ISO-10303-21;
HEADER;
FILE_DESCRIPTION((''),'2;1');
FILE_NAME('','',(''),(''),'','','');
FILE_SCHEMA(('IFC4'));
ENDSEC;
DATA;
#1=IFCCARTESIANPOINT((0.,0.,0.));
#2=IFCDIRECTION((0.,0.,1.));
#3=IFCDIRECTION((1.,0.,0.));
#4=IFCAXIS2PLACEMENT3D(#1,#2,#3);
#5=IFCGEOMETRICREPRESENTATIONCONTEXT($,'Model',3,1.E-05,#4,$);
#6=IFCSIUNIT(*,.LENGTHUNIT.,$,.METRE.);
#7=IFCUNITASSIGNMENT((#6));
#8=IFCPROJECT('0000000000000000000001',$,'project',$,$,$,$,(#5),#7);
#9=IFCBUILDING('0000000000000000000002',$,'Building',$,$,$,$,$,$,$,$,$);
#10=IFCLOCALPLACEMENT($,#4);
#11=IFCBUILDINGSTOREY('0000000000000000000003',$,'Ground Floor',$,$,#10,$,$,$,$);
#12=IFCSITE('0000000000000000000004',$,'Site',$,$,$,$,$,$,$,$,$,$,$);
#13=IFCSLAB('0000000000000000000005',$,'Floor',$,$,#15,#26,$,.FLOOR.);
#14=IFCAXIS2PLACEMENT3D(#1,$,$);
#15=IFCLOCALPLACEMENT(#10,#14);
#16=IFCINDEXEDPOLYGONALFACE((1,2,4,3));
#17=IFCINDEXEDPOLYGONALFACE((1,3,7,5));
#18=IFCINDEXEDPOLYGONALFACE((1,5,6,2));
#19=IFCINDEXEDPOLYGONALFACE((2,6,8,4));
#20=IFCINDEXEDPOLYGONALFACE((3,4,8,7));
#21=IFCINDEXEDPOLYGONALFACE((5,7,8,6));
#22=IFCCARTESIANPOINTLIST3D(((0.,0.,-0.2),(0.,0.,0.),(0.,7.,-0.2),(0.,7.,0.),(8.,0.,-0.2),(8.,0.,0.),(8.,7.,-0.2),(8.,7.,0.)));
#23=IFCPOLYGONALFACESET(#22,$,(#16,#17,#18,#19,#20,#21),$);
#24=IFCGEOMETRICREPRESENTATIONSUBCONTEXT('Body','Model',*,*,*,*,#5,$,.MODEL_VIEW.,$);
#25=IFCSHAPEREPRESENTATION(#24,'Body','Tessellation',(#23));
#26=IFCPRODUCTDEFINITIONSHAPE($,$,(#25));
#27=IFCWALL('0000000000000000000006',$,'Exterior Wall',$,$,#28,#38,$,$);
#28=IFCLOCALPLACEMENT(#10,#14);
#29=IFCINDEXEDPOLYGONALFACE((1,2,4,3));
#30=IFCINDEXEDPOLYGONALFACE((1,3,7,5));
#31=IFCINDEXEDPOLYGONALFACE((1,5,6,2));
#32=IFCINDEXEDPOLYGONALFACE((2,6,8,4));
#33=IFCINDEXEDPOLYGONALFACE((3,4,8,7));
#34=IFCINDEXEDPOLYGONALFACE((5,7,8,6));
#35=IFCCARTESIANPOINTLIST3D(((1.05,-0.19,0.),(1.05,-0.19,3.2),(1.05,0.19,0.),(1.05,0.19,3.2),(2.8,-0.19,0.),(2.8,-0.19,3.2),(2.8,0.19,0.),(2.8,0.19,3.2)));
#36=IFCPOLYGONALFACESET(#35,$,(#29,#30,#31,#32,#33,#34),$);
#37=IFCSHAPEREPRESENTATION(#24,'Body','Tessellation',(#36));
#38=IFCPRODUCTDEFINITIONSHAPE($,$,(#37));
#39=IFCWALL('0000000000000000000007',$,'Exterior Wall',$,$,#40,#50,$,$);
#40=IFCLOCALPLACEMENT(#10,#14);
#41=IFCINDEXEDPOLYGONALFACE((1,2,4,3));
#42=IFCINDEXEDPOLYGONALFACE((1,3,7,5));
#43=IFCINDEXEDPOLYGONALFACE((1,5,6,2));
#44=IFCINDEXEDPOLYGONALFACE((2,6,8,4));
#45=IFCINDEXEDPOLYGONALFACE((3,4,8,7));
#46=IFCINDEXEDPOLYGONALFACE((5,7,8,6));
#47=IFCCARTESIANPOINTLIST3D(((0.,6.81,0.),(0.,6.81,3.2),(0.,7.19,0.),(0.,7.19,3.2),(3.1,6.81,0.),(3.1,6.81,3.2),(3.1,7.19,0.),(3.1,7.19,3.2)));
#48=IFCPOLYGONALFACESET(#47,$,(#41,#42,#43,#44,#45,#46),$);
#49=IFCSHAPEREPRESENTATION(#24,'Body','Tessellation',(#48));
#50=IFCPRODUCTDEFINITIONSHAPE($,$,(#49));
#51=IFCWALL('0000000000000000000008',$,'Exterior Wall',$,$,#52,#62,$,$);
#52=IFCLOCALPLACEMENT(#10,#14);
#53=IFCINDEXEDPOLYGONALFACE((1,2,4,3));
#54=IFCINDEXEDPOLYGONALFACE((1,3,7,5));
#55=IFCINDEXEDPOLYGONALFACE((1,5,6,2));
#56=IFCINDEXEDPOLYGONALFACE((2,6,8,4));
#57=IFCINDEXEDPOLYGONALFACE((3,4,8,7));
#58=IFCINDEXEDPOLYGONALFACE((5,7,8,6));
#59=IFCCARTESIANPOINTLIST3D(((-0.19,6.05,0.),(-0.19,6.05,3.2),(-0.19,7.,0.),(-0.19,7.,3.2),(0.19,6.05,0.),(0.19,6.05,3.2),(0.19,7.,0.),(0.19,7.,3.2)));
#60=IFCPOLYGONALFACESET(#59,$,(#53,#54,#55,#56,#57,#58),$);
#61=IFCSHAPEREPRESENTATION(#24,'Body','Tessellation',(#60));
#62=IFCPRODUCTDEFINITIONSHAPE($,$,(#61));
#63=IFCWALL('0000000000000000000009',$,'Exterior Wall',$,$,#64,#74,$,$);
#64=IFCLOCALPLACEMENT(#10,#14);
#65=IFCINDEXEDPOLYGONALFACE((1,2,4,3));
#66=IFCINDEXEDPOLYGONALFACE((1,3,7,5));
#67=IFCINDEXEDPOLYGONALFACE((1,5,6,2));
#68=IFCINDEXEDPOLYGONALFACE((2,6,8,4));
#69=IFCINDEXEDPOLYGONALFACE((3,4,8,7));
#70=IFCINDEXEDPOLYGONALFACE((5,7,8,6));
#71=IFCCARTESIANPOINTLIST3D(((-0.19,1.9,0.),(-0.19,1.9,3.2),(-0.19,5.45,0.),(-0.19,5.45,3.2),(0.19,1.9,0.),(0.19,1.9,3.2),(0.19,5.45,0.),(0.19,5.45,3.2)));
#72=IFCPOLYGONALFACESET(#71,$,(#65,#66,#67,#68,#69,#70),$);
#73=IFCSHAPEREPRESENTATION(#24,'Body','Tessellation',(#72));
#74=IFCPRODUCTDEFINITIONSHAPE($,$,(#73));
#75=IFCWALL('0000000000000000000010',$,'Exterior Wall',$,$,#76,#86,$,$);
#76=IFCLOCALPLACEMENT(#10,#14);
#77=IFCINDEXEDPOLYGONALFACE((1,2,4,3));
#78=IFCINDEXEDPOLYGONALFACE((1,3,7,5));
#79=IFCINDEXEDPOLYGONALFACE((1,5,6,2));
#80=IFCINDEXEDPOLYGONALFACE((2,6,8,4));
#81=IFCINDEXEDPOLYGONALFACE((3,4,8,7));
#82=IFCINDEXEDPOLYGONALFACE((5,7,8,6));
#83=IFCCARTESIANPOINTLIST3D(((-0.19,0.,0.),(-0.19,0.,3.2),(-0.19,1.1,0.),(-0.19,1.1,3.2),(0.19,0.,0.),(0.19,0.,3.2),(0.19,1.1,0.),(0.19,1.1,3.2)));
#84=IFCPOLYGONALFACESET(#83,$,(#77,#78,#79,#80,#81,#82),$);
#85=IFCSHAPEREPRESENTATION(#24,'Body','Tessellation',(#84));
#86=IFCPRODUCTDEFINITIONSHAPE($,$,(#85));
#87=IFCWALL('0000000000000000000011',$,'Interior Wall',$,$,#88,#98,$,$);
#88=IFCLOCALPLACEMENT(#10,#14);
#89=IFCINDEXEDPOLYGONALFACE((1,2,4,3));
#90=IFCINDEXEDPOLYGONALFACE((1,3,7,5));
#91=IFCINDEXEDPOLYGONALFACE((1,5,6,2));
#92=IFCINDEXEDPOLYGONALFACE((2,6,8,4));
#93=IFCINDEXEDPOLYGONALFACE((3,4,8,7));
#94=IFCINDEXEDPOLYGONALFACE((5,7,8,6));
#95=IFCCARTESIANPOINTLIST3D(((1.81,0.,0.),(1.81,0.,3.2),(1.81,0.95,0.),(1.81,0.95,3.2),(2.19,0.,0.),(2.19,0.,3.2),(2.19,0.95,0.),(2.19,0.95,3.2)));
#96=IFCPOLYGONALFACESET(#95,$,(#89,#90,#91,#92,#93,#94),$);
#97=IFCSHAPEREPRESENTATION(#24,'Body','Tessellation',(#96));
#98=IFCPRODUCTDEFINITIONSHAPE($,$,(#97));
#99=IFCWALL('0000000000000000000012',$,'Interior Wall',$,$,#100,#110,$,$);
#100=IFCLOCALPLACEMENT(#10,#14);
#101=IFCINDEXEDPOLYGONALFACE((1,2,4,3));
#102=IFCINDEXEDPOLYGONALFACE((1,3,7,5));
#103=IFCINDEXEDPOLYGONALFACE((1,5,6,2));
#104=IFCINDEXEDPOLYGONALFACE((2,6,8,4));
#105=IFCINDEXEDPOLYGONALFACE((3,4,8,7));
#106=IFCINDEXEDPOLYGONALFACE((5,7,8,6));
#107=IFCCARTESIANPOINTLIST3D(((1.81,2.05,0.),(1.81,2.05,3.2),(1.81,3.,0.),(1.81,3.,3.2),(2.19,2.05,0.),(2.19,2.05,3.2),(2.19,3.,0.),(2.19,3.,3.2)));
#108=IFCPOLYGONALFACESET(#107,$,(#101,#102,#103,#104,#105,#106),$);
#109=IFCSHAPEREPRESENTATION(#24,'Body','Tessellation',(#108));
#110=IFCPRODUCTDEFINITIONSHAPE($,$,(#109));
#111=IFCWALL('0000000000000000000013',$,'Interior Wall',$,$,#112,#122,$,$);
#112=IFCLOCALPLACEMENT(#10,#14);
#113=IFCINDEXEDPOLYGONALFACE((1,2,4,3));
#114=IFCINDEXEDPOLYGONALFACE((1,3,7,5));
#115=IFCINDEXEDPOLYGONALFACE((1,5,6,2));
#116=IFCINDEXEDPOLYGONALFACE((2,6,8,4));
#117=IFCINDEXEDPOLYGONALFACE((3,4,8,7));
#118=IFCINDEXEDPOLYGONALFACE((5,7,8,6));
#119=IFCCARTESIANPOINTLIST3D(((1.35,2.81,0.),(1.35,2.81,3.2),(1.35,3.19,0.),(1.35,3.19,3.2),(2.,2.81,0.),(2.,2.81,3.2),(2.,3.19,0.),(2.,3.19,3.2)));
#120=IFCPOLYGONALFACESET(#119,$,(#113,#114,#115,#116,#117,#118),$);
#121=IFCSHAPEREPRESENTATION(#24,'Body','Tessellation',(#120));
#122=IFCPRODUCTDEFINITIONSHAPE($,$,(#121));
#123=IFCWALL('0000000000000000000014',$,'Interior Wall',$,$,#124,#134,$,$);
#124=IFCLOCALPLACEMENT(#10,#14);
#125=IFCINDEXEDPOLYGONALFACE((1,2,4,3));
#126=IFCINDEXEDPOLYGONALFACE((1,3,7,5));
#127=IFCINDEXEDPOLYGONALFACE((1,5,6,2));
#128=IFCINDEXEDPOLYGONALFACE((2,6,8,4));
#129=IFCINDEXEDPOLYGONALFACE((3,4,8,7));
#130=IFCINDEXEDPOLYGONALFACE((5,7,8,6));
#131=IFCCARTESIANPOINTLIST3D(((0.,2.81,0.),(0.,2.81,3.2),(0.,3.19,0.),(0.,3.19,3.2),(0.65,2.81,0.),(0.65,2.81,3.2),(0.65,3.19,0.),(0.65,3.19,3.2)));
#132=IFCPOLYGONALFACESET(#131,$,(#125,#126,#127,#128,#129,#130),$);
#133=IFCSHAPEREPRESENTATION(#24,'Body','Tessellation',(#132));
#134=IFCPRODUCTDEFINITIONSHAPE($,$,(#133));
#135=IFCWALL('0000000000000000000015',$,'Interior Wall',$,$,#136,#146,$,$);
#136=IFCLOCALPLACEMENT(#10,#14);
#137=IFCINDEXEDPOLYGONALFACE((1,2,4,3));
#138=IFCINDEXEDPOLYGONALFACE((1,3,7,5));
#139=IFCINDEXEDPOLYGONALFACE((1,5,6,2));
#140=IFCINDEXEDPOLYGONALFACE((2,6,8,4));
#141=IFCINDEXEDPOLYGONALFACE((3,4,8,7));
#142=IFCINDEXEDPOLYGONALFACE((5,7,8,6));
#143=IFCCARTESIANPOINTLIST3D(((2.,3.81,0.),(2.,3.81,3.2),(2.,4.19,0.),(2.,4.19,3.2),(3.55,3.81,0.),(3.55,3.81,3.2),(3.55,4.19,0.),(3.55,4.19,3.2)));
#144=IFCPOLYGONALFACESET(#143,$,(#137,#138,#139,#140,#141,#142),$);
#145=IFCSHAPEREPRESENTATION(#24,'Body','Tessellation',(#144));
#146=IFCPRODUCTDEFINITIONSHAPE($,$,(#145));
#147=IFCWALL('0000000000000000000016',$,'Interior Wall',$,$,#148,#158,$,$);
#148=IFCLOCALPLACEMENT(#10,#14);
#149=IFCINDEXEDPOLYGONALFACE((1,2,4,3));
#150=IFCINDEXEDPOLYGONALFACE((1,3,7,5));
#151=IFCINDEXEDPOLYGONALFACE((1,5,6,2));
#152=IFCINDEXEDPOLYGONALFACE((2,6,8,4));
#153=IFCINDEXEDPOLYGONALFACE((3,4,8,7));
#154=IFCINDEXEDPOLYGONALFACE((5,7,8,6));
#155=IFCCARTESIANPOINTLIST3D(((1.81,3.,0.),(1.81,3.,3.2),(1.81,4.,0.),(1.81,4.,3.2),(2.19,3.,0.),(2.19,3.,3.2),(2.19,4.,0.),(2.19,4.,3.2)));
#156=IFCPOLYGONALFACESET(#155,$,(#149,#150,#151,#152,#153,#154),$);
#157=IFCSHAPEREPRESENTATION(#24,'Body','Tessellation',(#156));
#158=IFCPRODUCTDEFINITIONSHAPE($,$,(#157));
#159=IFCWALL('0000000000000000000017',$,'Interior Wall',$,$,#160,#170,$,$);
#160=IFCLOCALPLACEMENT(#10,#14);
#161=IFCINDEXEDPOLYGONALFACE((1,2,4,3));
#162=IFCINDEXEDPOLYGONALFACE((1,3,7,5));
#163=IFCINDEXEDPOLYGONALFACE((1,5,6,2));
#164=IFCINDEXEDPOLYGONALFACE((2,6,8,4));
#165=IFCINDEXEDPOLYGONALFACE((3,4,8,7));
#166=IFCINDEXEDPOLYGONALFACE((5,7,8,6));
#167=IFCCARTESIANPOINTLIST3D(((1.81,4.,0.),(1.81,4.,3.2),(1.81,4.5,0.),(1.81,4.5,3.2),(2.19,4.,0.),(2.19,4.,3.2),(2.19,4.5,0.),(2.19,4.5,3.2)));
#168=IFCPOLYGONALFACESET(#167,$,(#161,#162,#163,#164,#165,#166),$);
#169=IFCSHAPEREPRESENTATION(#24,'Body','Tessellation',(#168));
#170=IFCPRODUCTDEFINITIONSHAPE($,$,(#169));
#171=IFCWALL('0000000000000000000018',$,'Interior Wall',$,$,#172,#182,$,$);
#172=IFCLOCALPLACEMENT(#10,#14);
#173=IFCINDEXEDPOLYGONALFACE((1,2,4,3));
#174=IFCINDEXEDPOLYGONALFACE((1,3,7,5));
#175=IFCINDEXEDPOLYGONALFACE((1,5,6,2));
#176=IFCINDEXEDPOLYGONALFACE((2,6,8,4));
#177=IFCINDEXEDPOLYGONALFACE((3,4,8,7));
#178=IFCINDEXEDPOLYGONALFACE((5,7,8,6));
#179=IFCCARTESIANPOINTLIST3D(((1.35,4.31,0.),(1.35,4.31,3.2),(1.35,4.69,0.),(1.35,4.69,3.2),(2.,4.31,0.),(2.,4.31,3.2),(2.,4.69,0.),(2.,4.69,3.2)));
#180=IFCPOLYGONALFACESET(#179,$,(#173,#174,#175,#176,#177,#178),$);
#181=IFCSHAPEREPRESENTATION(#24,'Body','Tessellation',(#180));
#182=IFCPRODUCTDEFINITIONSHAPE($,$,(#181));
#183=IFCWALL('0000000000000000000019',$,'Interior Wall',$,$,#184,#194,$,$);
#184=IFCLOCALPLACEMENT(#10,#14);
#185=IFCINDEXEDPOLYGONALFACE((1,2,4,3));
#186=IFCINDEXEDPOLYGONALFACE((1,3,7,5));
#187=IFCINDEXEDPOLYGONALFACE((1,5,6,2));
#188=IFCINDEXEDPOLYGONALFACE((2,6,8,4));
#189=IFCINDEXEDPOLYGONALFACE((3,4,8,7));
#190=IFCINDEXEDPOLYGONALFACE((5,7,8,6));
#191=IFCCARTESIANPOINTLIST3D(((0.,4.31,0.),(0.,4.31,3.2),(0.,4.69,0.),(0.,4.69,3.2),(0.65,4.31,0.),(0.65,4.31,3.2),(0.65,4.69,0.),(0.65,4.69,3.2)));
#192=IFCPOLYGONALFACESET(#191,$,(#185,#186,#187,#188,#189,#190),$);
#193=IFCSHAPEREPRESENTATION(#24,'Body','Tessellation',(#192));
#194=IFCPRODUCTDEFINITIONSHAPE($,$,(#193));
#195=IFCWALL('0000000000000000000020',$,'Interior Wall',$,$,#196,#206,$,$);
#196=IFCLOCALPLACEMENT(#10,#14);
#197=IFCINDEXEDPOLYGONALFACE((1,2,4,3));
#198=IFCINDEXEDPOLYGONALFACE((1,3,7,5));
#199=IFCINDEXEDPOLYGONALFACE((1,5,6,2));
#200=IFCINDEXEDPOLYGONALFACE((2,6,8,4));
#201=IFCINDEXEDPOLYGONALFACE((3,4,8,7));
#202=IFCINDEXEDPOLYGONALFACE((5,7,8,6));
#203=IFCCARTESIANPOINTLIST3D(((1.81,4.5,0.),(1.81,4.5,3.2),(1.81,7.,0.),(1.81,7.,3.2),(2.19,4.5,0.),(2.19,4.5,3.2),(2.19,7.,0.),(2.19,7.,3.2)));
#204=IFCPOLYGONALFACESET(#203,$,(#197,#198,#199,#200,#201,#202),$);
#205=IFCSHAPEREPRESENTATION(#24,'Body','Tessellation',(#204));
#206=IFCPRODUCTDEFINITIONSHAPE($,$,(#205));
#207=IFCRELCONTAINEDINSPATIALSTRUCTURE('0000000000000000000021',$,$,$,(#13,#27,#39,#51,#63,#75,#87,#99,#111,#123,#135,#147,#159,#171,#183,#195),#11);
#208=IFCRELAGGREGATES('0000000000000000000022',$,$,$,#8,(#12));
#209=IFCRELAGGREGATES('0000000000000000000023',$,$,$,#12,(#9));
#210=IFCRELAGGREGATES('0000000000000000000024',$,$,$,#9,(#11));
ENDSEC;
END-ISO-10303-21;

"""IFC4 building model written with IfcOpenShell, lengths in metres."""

from ifc_helpers import new_model, si_unit, frame, origin_with_axes, place, context, subcontext, project, spatial, indexed_curve, outline, extrude, element, save


model = new_model("IFC4")

# Units and contexts
model_context = context("Model", 3, precision=1e-05, world=origin_with_axes())
body_context = subcontext(model_context, "Body", "Model", "MODEL_VIEW")
ifc_project = project(units=[si_unit("LENGTHUNIT", "METRE")], contexts=[model_context])

# Site, building, storey
site = spatial("IfcSite", under=ifc_project, Name="Site")
building = spatial("IfcBuilding", under=site, Name="Building")
storey_placement = place(None, origin_with_axes())
storey = spatial("IfcBuildingStorey", under=building, at=storey_placement, Name="Ground Floor")

# Slab
slab_placement = place(storey_placement, frame((0.0, 0.0, -0.2), z_axis=(0.0, 0.0, 1.0), x_axis=(1.0, 0.0, 0.0)))
element("IfcSlab", 1, at=slab_placement, inside=storey, Name="Floor", PredefinedType="FLOOR", context=body_context, shape_type="SweptSolid", body=[
    extrude(outline(indexed_curve([(0.0, 0.0), (8.0, 0.0), (8.0, 7.0), (0.0, 7.0)])), None, (0.0, 0.0, 1.0), 0.2),
])

# Walls
wall_1_placement = place(storey_placement, frame((1.05, 0.0, 0.0), z_axis=(0.0, 0.0, 1.0), x_axis=(1.0, 0.0, 0.0)))
element("IfcWall", 2, at=wall_1_placement, inside=storey, Name="Exterior Wall", context=body_context, shape_type="SweptSolid", body=[
    extrude(outline(indexed_curve([(0.0, 0.0), (0.0, 0.38), (1.75, 0.38), (1.75, 0.0), (0.0, 0.0)], self_intersect=False)), frame((0.0, -0.19, 0.0), z_axis=(0.0, 0.0, 1.0), x_axis=(1.0, 0.0, 0.0)), (0.0, 0.0, 1.0), 3.2),
])
wall_2_placement = place(storey_placement, frame((3.1, 7.0, 0.0), z_axis=(0.0, 0.0, 1.0), x_axis=(-1.0, 0.0, 0.0)))
element("IfcWall", 3, at=wall_2_placement, inside=storey, Name="Exterior Wall", context=body_context, shape_type="SweptSolid", body=[
    extrude(outline(indexed_curve([(0.0, 0.0), (0.0, 0.38), (3.1, 0.38), (3.1, 0.0), (0.0, 0.0)], self_intersect=False)), frame((0.0, -0.19, 0.0), z_axis=(0.0, 0.0, 1.0), x_axis=(1.0, 0.0, 0.0)), (0.0, 0.0, 1.0), 3.2),
])
wall_3_placement = place(storey_placement, frame((0.0, 7.0, 0.0), z_axis=(0.0, 0.0, 1.0), x_axis=(0.0, -1.0, 0.0)))
element("IfcWall", 4, at=wall_3_placement, inside=storey, Name="Exterior Wall", context=body_context, shape_type="SweptSolid", body=[
    extrude(outline(indexed_curve([(0.0, 0.0), (0.0, 0.38), (0.95, 0.38), (0.95, 0.0), (0.0, 0.0)], self_intersect=False)), frame((0.0, -0.19, 0.0), z_axis=(0.0, 0.0, 1.0), x_axis=(1.0, 0.0, 0.0)), (0.0, 0.0, 1.0), 3.2),
])
wall_4_placement = place(storey_placement, frame((0.0, 5.45, 0.0), z_axis=(0.0, 0.0, 1.0), x_axis=(0.0, -1.0, 0.0)))
element("IfcWall", 5, at=wall_4_placement, inside=storey, Name="Exterior Wall", context=body_context, shape_type="SweptSolid", body=[
    extrude(outline(indexed_curve([(0.0, 0.0), (0.0, 0.38), (3.55, 0.38), (3.55, 0.0), (0.0, 0.0)], self_intersect=False)), frame((0.0, -0.19, 0.0), z_axis=(0.0, 0.0, 1.0), x_axis=(1.0, 0.0, 0.0)), (0.0, 0.0, 1.0), 3.2),
])
wall_5_placement = place(storey_placement, frame((0.0, 1.1, 0.0), z_axis=(0.0, 0.0, 1.0), x_axis=(0.0, -1.0, 0.0)))
element("IfcWall", 6, at=wall_5_placement, inside=storey, Name="Exterior Wall", context=body_context, shape_type="SweptSolid", body=[
    extrude(outline(indexed_curve([(0.0, 0.0), (0.0, 0.38), (1.1, 0.38), (1.1, 0.0), (0.0, 0.0)], self_intersect=False)), frame((0.0, -0.19, 0.0), z_axis=(0.0, 0.0, 1.0), x_axis=(1.0, 0.0, 0.0)), (0.0, 0.0, 1.0), 3.2),
])
wall_6_placement = place(storey_placement, frame((2.0, 0.0, 0.0), z_axis=(0.0, 0.0, 1.0), x_axis=(0.0, 1.0, 0.0)))
element("IfcWall", 7, at=wall_6_placement, inside=storey, Name="Interior Wall", context=body_context, shape_type="SweptSolid", body=[
    extrude(outline(indexed_curve([(0.0, 0.0), (0.0, 0.38), (0.95, 0.38), (0.95, 0.0), (0.0, 0.0)], self_intersect=False)), frame((0.0, -0.19, 0.0), z_axis=(0.0, 0.0, 1.0), x_axis=(1.0, 0.0, 0.0)), (0.0, 0.0, 1.0), 3.2),
])
wall_7_placement = place(storey_placement, frame((2.0, 2.05, 0.0), z_axis=(0.0, 0.0, 1.0), x_axis=(0.0, 1.0, 0.0)))
element("IfcWall", 8, at=wall_7_placement, inside=storey, Name="Interior Wall", context=body_context, shape_type="SweptSolid", body=[
    extrude(outline(indexed_curve([(0.0, 0.0), (0.0, 0.38), (0.95, 0.38), (0.95, 0.0), (0.0, 0.0)], self_intersect=False)), frame((0.0, -0.19, 0.0), z_axis=(0.0, 0.0, 1.0), x_axis=(1.0, 0.0, 0.0)), (0.0, 0.0, 1.0), 3.2),
])
for number, where, z_axis, x_axis, name in (
    (9, (2.0, 3.0, 0.0), (0.0, 0.0, 1.0), (-1.0, 0.0, 0.0), "Interior Wall"),
    (10, (0.65, 3.0, 0.0), (0.0, 0.0, 1.0), (-1.0, 0.0, 0.0), "Interior Wall"),
):
    element("IfcWall", number, at=place(storey_placement, frame(where, z_axis=z_axis, x_axis=x_axis)), inside=storey, Name=name, context=body_context, shape_type="SweptSolid", body=[
        extrude(outline(indexed_curve([(0.0, 0.0), (0.0, 0.38), (0.65, 0.38), (0.65, 0.0), (0.0, 0.0)], self_intersect=False)), frame((0.0, -0.19, 0.0), z_axis=(0.0, 0.0, 1.0), x_axis=(1.0, 0.0, 0.0)), (0.0, 0.0, 1.0), 3.2),
    ])
wall_8_placement = place(storey_placement, frame((3.55, 4.0, 0.0), z_axis=(0.0, 0.0, 1.0), x_axis=(-1.0, 0.0, 0.0)))
element("IfcWall", 11, at=wall_8_placement, inside=storey, Name="Interior Wall", context=body_context, shape_type="SweptSolid", body=[
    extrude(outline(indexed_curve([(0.0, 0.0), (0.0, 0.38), (1.55, 0.38), (1.55, 0.0), (0.0, 0.0)], self_intersect=False)), frame((0.0, -0.19, 0.0), z_axis=(0.0, 0.0, 1.0), x_axis=(1.0, 0.0, 0.0)), (0.0, 0.0, 1.0), 3.2),
])
wall_9_placement = place(storey_placement, frame((2.0, 4.0, 0.0), z_axis=(0.0, 0.0, 1.0), x_axis=(0.0, -1.0, 0.0)))
element("IfcWall", 12, at=wall_9_placement, inside=storey, Name="Interior Wall", context=body_context, shape_type="SweptSolid", body=[
    extrude(outline(indexed_curve([(0.0, 0.0), (0.0, 0.38), (1.0, 0.38), (1.0, 0.0), (0.0, 0.0)], self_intersect=False)), frame((0.0, -0.19, 0.0), z_axis=(0.0, 0.0, 1.0), x_axis=(1.0, 0.0, 0.0)), (0.0, 0.0, 1.0), 3.2),
])
wall_10_placement = place(storey_placement, frame((2.0, 4.0, 0.0), z_axis=(0.0, 0.0, 1.0), x_axis=(0.0, 1.0, 0.0)))
element("IfcWall", 13, at=wall_10_placement, inside=storey, Name="Interior Wall", context=body_context, shape_type="SweptSolid", body=[
    extrude(outline(indexed_curve([(0.0, 0.0), (0.0, 0.38), (0.5, 0.38), (0.5, 0.0), (0.0, 0.0)], self_intersect=False)), frame((0.0, -0.19, 0.0), z_axis=(0.0, 0.0, 1.0), x_axis=(1.0, 0.0, 0.0)), (0.0, 0.0, 1.0), 3.2),
])
for number, where, z_axis, x_axis, name in (
    (14, (2.0, 4.5, 0.0), (0.0, 0.0, 1.0), (-1.0, 0.0, 0.0), "Interior Wall"),
    (15, (0.65, 4.5, 0.0), (0.0, 0.0, 1.0), (-1.0, 0.0, 0.0), "Interior Wall"),
):
    element("IfcWall", number, at=place(storey_placement, frame(where, z_axis=z_axis, x_axis=x_axis)), inside=storey, Name=name, context=body_context, shape_type="SweptSolid", body=[
        extrude(outline(indexed_curve([(0.0, 0.0), (0.0, 0.38), (0.65, 0.38), (0.65, 0.0), (0.0, 0.0)], self_intersect=False)), frame((0.0, -0.19, 0.0), z_axis=(0.0, 0.0, 1.0), x_axis=(1.0, 0.0, 0.0)), (0.0, 0.0, 1.0), 3.2),
    ])
wall_11_placement = place(storey_placement, frame((2.0, 4.5, 0.0), z_axis=(0.0, 0.0, 1.0), x_axis=(0.0, 1.0, 0.0)))
element("IfcWall", 16, at=wall_11_placement, inside=storey, Name="Interior Wall", context=body_context, shape_type="SweptSolid", body=[
    extrude(outline(indexed_curve([(0.0, 0.0), (0.0, 0.38), (2.5, 0.38), (2.5, 0.0), (0.0, 0.0)], self_intersect=False)), frame((0.0, -0.19, 0.0), z_axis=(0.0, 0.0, 1.0), x_axis=(1.0, 0.0, 0.0)), (0.0, 0.0, 1.0), 3.2),
])

save(model, "model.ifc")
